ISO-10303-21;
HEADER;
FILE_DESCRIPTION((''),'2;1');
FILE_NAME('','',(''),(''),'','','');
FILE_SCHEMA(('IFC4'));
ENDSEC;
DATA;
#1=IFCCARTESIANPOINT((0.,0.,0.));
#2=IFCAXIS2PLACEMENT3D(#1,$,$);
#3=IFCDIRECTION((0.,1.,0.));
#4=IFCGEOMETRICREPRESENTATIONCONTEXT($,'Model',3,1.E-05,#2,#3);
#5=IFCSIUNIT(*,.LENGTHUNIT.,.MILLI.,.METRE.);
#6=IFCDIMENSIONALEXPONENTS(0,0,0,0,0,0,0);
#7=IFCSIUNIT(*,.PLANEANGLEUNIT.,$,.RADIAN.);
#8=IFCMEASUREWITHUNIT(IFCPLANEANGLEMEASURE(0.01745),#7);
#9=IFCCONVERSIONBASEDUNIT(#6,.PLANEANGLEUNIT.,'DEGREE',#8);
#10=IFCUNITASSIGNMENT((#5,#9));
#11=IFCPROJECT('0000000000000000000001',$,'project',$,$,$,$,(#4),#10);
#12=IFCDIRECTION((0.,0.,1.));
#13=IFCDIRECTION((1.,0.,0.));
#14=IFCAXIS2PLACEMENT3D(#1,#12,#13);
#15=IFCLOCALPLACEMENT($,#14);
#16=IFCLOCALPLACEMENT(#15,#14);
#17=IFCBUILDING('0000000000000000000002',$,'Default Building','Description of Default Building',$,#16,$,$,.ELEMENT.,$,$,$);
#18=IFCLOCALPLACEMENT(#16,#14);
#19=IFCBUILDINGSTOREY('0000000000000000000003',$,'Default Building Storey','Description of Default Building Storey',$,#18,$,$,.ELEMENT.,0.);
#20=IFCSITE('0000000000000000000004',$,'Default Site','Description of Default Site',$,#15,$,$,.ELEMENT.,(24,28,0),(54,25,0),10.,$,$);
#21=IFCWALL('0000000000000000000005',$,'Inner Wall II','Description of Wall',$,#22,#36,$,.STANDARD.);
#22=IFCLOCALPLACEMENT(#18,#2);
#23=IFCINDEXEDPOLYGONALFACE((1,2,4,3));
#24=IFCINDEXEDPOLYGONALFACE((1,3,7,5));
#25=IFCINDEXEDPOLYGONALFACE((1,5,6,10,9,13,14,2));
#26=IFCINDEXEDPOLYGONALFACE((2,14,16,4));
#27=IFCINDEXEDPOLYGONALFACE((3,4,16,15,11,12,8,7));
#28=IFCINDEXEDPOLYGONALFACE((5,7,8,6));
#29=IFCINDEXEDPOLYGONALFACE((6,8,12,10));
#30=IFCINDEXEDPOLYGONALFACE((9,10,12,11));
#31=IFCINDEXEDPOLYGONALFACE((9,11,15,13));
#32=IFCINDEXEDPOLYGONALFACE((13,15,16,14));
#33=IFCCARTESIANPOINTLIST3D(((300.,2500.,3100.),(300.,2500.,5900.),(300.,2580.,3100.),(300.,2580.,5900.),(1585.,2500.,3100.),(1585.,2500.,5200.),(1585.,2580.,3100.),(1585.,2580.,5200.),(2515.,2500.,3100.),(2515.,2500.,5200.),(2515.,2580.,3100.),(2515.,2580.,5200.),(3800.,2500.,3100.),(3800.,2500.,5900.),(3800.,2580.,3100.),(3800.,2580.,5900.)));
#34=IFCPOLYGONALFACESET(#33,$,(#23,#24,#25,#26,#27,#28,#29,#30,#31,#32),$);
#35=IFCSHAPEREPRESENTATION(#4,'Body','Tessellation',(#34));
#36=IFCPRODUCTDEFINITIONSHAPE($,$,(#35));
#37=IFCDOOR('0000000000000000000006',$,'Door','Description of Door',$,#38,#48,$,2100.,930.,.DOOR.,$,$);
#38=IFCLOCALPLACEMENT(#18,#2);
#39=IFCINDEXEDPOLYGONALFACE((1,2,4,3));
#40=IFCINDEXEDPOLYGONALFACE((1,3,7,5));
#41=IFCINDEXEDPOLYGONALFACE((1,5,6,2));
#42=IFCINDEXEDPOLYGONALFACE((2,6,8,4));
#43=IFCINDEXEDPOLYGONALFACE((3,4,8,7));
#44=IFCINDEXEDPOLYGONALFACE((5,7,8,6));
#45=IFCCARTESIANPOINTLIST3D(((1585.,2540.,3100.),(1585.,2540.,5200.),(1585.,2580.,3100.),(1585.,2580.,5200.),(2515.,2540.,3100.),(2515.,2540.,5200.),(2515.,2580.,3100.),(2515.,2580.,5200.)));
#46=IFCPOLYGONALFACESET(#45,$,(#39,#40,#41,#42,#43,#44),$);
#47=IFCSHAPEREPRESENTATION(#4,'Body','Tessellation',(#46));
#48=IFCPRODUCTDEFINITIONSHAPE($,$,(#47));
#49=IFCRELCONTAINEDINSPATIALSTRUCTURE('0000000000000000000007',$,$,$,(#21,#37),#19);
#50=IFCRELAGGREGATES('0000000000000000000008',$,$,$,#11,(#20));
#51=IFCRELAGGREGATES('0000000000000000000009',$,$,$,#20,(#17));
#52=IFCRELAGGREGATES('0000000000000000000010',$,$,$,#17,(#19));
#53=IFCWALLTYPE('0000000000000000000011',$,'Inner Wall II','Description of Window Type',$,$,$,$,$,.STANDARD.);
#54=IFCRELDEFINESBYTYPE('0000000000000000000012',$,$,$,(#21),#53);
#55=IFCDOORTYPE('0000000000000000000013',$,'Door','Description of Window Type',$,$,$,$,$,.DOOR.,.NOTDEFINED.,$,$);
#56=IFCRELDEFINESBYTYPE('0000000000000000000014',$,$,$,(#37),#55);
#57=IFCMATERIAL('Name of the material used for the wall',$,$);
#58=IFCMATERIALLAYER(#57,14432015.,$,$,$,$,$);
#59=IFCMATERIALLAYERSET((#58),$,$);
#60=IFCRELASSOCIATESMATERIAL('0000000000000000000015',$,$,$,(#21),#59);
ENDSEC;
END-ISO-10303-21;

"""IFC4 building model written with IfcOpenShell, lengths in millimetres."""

from ifc_helpers import new_model, entity, si_unit, converted_unit, direction, frame, origin, origin_with_axes, place, context, project, spatial, polyline, outline, extrude, material, layer, layer_set, layer_usage, type_object, element, fill, save


model = new_model("IFC4")

# Units and contexts
model_context = context("Model", 3, precision=1e-05, world=origin(), true_north=direction((0.0, 1.0, 0.0)))
ifc_project = project(units=[si_unit("LENGTHUNIT", "METRE", prefix="MILLI"), converted_unit("PLANEANGLEUNIT", "DEGREE", entity("IfcPlaneAngleMeasure", 0.01745), si_unit("PLANEANGLEUNIT", "RADIAN"), dimensions=[0, 0, 0, 0, 0, 0, 0])], contexts=[model_context])

# Site, building, storey
site_placement = place(None, origin_with_axes())
site = spatial("IfcSite", under=ifc_project, at=site_placement, Name="Default Site", Description="Description of Default Site", CompositionType="ELEMENT", RefLatitude=(24, 28, 0), RefLongitude=(54, 25, 0), RefElevation=10.0)
building_placement = place(site_placement, origin_with_axes())
building = spatial("IfcBuilding", under=site, at=building_placement, Name="Default Building", Description="Description of Default Building", CompositionType="ELEMENT")
storey_placement = place(building_placement, origin_with_axes())
storey = spatial("IfcBuildingStorey", under=building, at=storey_placement, Name="Default Building Storey", Description="Description of Default Building Storey", CompositionType="ELEMENT", Elevation=0.0)

# Wall, opening, door
ifc_material_1 = material(Name="Name of the material used for the wall")
ifc_layer_1 = layer(ifc_material_1, 14432015.0)
ifc_layer_set_1 = layer_set([ifc_layer_1])
ifc_layer_usage_1 = layer_usage(ifc_layer_set_1, "AXIS2", "POSITIVE", -7216007.5)
wall_type_1 = type_object("IfcWallType", Name="Inner Wall II", Description="Description of Window Type", PredefinedType="STANDARD")
wall_1_placement = place(storey_placement, frame((3800.0, 2540.0, 3100.0), z_axis=(0.0, 0.0, 1.0), x_axis=(-1.0, 0.0, 0.0)))
wall_1 = element("IfcWall", 1, at=wall_1_placement, inside=storey, type_object=wall_type_1, material=ifc_layer_usage_1, Name="Inner Wall II", Description="Description of Wall", PredefinedType="STANDARD", context=model_context, shape_type="SweptSolid", body=[
    extrude(outline(polyline([(0.0, -40.0), (0.0, 40.0), (3500.0, 40.0), (3500.0, -40.0), (0.0, -40.0)])), origin_with_axes(), (0.0, 0.0, 1.0), 2800.0),
])
opening_1_placement = place(wall_1_placement, frame((1285.0, -40.0, 0.0), z_axis=(0.0, 0.0, 1.0), x_axis=(1.0, 0.0, 0.0)))
opening_1 = element("IfcOpeningElement", 2, at=opening_1_placement, cuts=wall_1, context=model_context, shape_type="SweptSolid", body=[
    extrude(outline(polyline([(0.0, 0.0), (0.0, 80.0), (930.0, 80.0), (930.0, 0.0), (0.0, 0.0)])), origin_with_axes(), (0.0, 0.0, 1.0), 2100.0),
])
door_type_1 = type_object("IfcDoorType", Name="Door", Description="Description of Window Type", PredefinedType="DOOR")
door_1_placement = place(opening_1_placement, origin_with_axes())
door_1 = element("IfcDoor", 3, at=door_1_placement, inside=storey, type_object=door_type_1, Name="Door", Description="Description of Door", OverallHeight=2100.0, OverallWidth=930.0, PredefinedType="DOOR", context=model_context, shape_type="SweptSolid", body=[
    extrude(outline(polyline([(0.0, 0.0), (0.0, 40.0), (930.0, 40.0), (930.0, 0.0), (0.0, 0.0)])), origin_with_axes(), (0.0, 0.0, 1.0), 2100.0),
])
fill(opening_1, door_1)

save(model, "model.ifc")
